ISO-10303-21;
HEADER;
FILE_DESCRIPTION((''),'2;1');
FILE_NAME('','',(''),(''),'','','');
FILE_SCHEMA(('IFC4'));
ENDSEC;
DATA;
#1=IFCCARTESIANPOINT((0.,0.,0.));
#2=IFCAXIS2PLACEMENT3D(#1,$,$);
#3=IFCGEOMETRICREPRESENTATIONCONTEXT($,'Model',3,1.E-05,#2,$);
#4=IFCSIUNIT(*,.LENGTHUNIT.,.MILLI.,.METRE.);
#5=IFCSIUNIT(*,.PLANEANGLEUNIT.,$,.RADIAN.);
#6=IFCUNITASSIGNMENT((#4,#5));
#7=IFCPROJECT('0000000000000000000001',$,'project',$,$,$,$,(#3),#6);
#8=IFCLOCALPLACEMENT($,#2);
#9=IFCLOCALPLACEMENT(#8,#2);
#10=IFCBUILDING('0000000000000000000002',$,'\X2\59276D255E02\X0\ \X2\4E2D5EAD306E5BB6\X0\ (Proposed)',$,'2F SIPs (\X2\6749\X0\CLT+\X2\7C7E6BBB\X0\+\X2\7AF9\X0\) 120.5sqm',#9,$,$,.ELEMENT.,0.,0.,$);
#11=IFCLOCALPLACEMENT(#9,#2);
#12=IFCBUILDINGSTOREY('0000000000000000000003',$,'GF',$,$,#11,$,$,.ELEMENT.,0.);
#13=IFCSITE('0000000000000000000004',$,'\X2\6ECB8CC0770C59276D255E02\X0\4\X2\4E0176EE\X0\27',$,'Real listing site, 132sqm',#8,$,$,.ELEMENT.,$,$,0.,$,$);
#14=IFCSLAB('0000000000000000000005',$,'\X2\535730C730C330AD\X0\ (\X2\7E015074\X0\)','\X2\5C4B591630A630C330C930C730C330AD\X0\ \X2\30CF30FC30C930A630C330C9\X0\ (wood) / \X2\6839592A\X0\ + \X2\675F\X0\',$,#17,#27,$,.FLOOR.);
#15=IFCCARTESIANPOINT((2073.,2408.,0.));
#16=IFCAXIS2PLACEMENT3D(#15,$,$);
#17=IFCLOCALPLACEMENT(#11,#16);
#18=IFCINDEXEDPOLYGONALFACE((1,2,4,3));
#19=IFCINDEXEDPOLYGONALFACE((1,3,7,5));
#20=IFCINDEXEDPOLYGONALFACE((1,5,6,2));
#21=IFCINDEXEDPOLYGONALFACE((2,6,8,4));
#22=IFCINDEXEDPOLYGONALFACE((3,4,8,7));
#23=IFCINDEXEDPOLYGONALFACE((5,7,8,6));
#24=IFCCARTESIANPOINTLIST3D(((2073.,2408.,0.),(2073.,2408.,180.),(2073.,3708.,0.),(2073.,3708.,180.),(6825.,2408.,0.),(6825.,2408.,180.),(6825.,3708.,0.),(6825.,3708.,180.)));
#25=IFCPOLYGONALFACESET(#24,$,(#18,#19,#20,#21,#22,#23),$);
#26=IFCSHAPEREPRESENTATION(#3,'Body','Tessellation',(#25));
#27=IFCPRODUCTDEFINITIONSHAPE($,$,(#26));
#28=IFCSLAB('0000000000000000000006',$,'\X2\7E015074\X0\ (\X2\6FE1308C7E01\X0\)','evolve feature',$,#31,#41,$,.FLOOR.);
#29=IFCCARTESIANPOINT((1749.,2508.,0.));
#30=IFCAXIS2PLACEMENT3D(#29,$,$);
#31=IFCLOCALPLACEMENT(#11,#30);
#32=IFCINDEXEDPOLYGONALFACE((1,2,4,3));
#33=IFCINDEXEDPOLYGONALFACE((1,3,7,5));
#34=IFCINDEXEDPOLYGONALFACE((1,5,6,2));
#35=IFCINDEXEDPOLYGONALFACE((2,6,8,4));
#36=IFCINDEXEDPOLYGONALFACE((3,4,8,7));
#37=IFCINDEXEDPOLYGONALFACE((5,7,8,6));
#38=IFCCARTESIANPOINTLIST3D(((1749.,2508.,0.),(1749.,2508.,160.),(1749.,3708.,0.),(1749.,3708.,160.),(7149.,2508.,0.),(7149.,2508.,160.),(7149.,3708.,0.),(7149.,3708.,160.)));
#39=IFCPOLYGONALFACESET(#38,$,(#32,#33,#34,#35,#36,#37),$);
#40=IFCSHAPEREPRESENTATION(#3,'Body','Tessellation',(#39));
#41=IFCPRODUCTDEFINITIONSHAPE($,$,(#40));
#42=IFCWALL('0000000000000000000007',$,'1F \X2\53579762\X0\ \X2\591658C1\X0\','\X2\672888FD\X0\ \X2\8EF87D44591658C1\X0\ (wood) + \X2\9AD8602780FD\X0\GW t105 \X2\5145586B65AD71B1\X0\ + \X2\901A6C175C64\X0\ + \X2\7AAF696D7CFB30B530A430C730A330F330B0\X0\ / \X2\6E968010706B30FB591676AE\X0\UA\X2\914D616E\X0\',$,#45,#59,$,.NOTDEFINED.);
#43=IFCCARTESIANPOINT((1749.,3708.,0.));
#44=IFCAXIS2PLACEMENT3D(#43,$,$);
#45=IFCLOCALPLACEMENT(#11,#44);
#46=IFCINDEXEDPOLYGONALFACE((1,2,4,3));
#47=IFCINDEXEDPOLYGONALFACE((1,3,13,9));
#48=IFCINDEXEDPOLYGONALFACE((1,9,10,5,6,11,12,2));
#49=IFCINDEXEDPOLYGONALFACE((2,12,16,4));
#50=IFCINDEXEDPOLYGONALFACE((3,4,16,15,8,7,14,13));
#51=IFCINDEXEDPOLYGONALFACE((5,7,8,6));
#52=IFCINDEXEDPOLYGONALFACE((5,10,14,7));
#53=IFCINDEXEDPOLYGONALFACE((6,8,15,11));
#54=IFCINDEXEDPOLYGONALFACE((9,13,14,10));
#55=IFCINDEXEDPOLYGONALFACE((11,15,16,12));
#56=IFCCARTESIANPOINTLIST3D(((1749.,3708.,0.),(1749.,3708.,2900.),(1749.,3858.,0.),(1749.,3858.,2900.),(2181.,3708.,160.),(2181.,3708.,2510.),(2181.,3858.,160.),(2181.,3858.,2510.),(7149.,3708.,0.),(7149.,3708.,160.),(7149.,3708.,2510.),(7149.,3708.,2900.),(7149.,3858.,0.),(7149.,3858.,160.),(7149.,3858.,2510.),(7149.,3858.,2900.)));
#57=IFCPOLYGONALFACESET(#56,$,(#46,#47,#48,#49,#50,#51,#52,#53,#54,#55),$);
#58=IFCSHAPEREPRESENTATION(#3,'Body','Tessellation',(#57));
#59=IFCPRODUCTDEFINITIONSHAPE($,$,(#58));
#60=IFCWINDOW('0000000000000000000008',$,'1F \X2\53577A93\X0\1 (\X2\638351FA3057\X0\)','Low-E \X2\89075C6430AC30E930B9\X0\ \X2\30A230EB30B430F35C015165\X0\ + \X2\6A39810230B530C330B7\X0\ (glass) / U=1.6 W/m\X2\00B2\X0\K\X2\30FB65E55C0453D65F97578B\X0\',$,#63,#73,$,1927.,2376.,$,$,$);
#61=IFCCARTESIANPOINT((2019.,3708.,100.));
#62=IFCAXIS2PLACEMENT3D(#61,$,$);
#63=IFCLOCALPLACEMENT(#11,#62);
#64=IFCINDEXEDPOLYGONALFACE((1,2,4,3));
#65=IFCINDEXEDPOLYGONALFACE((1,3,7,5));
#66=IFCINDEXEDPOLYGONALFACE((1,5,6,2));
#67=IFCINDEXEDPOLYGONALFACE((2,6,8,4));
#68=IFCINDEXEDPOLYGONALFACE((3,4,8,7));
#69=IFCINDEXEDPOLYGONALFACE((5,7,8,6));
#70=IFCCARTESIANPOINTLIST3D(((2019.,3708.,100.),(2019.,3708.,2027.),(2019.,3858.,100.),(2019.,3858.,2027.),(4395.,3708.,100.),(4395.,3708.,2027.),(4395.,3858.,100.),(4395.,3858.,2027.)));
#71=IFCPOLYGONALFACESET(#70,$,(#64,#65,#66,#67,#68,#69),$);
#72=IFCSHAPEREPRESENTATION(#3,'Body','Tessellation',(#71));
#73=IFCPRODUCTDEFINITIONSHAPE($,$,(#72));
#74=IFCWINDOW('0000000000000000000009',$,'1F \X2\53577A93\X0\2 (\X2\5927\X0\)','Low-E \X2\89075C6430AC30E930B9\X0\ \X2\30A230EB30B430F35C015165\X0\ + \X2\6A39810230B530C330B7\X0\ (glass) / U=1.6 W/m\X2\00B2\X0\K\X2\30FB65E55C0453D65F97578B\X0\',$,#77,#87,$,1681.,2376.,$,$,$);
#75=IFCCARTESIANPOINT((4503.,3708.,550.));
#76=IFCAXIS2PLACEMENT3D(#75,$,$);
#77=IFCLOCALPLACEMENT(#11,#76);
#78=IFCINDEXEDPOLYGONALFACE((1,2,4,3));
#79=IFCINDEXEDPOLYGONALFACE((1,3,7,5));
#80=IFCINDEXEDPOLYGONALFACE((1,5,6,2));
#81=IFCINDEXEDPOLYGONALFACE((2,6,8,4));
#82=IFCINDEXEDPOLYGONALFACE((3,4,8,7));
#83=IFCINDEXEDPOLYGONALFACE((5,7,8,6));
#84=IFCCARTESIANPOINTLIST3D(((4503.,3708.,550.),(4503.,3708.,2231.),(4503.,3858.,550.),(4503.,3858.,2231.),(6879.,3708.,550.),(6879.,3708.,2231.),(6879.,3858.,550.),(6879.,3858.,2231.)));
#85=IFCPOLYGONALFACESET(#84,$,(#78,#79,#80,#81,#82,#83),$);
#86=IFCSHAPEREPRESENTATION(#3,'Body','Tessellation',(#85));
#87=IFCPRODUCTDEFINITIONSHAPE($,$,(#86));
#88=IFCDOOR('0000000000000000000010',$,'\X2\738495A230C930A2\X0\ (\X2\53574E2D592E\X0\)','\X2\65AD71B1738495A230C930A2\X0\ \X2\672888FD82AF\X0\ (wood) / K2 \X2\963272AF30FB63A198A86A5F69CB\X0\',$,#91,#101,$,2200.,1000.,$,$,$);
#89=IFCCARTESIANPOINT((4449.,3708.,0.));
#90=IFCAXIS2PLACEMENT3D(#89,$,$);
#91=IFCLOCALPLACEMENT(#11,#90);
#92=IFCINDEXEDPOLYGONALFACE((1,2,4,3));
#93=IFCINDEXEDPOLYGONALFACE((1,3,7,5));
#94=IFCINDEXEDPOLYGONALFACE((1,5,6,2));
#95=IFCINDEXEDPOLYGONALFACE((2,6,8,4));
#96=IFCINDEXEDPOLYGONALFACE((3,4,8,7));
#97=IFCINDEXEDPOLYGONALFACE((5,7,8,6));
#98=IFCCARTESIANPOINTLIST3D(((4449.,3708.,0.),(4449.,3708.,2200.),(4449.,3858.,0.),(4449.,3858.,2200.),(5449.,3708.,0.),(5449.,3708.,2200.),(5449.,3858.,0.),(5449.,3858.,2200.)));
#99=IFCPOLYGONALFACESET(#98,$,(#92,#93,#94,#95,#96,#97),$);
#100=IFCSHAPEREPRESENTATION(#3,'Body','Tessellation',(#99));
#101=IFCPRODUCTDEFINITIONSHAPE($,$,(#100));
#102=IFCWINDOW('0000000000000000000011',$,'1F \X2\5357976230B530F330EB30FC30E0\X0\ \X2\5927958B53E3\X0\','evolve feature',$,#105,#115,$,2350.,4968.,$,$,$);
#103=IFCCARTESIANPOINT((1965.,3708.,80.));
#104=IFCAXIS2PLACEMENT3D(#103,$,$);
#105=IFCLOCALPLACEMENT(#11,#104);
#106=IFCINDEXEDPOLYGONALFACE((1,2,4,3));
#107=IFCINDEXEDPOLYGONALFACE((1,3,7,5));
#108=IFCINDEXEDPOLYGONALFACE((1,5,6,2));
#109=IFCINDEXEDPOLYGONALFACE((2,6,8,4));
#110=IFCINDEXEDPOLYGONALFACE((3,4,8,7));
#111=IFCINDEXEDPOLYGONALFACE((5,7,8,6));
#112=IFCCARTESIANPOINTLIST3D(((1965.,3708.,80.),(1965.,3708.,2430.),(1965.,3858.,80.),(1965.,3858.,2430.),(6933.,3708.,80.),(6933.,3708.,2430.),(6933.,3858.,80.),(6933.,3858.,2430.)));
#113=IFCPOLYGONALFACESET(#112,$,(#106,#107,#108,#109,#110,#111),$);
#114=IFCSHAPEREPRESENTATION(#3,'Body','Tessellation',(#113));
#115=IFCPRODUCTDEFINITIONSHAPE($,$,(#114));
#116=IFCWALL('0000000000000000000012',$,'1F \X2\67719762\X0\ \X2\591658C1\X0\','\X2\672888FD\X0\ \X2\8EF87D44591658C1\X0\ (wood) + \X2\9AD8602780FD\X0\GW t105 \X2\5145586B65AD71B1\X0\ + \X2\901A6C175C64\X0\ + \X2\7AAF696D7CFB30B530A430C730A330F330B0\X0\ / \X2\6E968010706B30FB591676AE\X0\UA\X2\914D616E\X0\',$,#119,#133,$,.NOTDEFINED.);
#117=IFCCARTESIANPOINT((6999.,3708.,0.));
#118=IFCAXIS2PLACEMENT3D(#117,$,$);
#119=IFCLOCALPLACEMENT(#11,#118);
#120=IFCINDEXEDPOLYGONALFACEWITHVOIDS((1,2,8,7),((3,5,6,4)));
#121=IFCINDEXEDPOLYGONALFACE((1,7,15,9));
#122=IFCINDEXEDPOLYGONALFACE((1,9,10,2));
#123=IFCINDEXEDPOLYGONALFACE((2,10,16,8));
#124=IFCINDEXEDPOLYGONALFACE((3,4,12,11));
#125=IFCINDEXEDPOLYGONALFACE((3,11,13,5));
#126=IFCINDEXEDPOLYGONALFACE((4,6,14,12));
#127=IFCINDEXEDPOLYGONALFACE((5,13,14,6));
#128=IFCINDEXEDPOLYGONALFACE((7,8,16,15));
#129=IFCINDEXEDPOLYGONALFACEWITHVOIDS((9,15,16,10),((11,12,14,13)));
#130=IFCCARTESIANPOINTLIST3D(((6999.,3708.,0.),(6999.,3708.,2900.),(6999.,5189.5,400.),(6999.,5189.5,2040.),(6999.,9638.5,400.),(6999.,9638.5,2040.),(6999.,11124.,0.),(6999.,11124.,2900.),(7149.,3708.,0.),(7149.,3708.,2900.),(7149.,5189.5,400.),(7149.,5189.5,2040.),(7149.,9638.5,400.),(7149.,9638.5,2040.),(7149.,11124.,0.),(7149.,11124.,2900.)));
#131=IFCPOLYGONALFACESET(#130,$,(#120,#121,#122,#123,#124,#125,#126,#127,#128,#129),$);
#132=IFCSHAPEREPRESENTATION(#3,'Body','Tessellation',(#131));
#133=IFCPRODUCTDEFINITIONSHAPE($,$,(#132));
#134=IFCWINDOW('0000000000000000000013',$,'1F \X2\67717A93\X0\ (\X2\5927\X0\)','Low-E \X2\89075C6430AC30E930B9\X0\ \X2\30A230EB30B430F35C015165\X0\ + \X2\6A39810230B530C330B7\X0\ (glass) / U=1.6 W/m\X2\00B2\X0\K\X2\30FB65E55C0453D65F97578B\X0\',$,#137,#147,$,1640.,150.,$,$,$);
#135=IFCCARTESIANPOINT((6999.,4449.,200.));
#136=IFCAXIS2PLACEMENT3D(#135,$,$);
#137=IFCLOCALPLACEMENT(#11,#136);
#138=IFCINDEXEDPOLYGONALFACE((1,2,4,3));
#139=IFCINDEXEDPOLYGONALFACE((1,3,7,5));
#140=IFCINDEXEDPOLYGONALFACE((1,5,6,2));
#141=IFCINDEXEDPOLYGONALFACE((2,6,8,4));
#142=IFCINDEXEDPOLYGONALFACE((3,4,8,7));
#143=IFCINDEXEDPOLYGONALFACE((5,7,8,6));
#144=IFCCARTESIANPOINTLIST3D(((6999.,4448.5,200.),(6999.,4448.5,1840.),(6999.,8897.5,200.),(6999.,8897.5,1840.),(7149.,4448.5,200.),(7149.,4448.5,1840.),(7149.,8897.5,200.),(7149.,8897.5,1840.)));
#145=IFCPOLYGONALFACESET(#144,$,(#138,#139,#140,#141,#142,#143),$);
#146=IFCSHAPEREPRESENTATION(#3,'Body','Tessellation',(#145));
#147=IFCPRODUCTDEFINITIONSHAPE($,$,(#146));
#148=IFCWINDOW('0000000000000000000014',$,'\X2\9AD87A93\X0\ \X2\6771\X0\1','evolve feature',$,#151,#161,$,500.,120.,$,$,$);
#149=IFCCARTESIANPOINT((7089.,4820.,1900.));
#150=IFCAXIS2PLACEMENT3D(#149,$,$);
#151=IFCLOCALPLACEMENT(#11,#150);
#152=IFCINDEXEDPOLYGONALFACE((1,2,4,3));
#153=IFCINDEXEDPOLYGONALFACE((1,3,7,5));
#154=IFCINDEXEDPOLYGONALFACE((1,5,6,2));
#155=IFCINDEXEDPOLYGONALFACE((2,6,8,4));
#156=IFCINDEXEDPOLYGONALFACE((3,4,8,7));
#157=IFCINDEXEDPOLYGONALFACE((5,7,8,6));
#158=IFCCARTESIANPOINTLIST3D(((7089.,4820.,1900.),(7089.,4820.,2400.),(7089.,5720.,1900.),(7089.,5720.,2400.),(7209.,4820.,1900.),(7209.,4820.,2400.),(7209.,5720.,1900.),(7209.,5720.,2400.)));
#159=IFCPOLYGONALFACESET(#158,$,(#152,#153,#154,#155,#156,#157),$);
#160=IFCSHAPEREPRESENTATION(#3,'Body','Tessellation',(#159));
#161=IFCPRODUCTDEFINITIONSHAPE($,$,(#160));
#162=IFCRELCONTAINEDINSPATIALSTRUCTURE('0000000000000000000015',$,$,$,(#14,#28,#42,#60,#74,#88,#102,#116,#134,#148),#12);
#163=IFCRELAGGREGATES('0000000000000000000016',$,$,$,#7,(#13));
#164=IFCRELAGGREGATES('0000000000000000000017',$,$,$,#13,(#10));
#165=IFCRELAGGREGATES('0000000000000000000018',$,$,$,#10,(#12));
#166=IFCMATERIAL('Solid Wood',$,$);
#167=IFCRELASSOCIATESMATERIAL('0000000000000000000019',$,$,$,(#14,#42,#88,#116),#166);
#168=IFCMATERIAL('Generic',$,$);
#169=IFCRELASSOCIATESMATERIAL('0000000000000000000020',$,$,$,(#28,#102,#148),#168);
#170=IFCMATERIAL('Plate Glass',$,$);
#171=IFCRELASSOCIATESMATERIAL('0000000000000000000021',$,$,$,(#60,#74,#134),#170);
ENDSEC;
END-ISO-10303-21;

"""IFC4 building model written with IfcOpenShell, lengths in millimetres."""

from ifc_helpers import new_model, si_unit, frame, frame_2d, origin, place, context, project, spatial, rectangle, extrude, material, element, fill, save


model = new_model("IFC4")

# Units and contexts
model_context = context("Model", 3, precision=1e-05, world=origin())
ifc_project = project(units=[si_unit("LENGTHUNIT", "METRE", prefix="MILLI"), si_unit("PLANEANGLEUNIT", "RADIAN")], contexts=[model_context])

# Site, building, storey
site_placement = place(None, origin())
site = spatial("IfcSite", under=ifc_project, at=site_placement, Name="滋賀県大津市4丁目27", ObjectType="Real listing site, 132sqm", CompositionType="ELEMENT", RefElevation=0.0)
building_placement = place(site_placement, origin())
building = spatial("IfcBuilding", under=site, at=building_placement, Name="大津市 中庭の家 (Proposed)", ObjectType="2F SIPs (杉CLT+籾殻+竹) 120.5sqm", CompositionType="ELEMENT", ElevationOfRefHeight=0.0, ElevationOfTerrain=0.0)
storey_placement = place(building_placement, origin())
storey = spatial("IfcBuildingStorey", under=building, at=storey_placement, Name="GF", CompositionType="ELEMENT", Elevation=0.0)

# Slabs
ifc_material_1 = material(Name="Solid Wood")
slab_1_placement = place(storey_placement, frame((2073.0, 2408.0, 0.0)))
element("IfcSlab", 1, at=slab_1_placement, inside=storey, material=ifc_material_1, Name="南デッキ (縁側)", Description="屋外ウッドデッキ ハードウッド (wood) / 根太 + 束", PredefinedType="FLOOR", context=model_context, shape_type="SweptSolid", body=[
    extrude(rectangle(XDim=4752.0, YDim=1300.0, at=frame_2d((2376.0, 650.0))), frame((2073.0, 2408.0, 0.0)), (0.0, 0.0, 1.0), 180.0),
])
ifc_material_2 = material(Name="Generic")
slab_2_placement = place(storey_placement, frame((1749.0, 2508.0, 0.0)))
element("IfcSlab", 2, at=slab_2_placement, inside=storey, material=ifc_material_2, Name="縁側 (濡れ縁)", Description="evolve feature", PredefinedType="FLOOR", context=model_context, shape_type="SweptSolid", body=[
    extrude(rectangle(XDim=5400.0, YDim=1200.0, at=frame_2d((2700.0, 600.0))), frame((1749.0, 2508.0, 0.0)), (0.0, 0.0, 1.0), 160.0),
])

# Wall, openings, windows, door
wall_1_placement = place(storey_placement, frame((1749.0, 3708.0, 0.0)))
wall_1 = element("IfcWall", 3, at=wall_1_placement, inside=storey, material=ifc_material_1, Name="1F 南面 外壁", Description="木製 軸組外壁 (wood) + 高性能GW t105 充填断熱 + 通気層 + 窯業系サイディング / 準耐火・外皮UA配慮", PredefinedType="NOTDEFINED", context=model_context, shape_type="SweptSolid", body=[
    extrude(rectangle(XDim=5400.0, YDim=150.0, at=frame_2d((2700.0, 75.0))), frame((1749.0, 3708.0, 0.0)), (0.0, 0.0, 1.0), 2900.0),
])
opening_1_placement = place(storey_placement, frame((2019.0, 3708.0, 100.0)))
opening_1 = element("IfcOpeningElement", 4, at=opening_1_placement, cuts=wall_1, PredefinedType="NOTDEFINED", context=model_context, shape_type="SweptSolid", body=[
    extrude(rectangle(XDim=2376.0, YDim=150.0, at=frame_2d((1188.0, 75.0))), frame((2019.0, 3708.0, 100.0)), (0.0, 0.0, 1.0), 1927.0),
])
opening_2_placement = place(storey_placement, frame((4503.0, 3708.0, 550.0)))
opening_2 = element("IfcOpeningElement", 5, at=opening_2_placement, cuts=wall_1, PredefinedType="NOTDEFINED", context=model_context, shape_type="SweptSolid", body=[
    extrude(rectangle(XDim=2376.0, YDim=150.0, at=frame_2d((1188.0, 75.0))), frame((4503.0, 3708.0, 550.0)), (0.0, 0.0, 1.0), 1681.0),
])
opening_3_placement = place(storey_placement, frame((4449.0, 3708.0, 0.0)))
opening_3 = element("IfcOpeningElement", 6, at=opening_3_placement, cuts=wall_1, PredefinedType="NOTDEFINED", context=model_context, shape_type="SweptSolid", body=[
    extrude(rectangle(XDim=1000.0, YDim=150.0, at=frame_2d((500.0, 75.0))), frame((4449.0, 3708.0, 0.0)), (0.0, 0.0, 1.0), 2200.0),
])
opening_4_placement = place(storey_placement, frame((1965.0, 3708.0, 80.0)))
opening_4 = element("IfcOpeningElement", 7, at=opening_4_placement, cuts=wall_1, PredefinedType="NOTDEFINED", context=model_context, shape_type="SweptSolid", body=[
    extrude(rectangle(XDim=4968.0, YDim=150.0, at=frame_2d((2484.0, 75.0))), frame((1965.0, 3708.0, 80.0)), (0.0, 0.0, 1.0), 2350.0),
])
ifc_material_3 = material(Name="Plate Glass")
window_1_placement = place(storey_placement, frame((2019.0, 3708.0, 100.0)))
window_1 = element("IfcWindow", 8, at=window_1_placement, inside=storey, material=ifc_material_3, Name="1F 南窓1 (掃出し)", Description="Low-E 複層ガラス アルゴン封入 + 樹脂サッシ (glass) / U=1.6 W/m²K・日射取得型", OverallHeight=1927.0, OverallWidth=2376.0, context=model_context, shape_type="SweptSolid", body=[
    extrude(rectangle(XDim=2376.0, YDim=150.0, at=frame_2d((1188.0, 75.0))), frame((2019.0, 3708.0, 100.0)), (0.0, 0.0, 1.0), 1927.0),
])
fill(opening_1, window_1)
window_2_placement = place(storey_placement, frame((4503.0, 3708.0, 550.0)))
window_2 = element("IfcWindow", 9, at=window_2_placement, inside=storey, material=ifc_material_3, Name="1F 南窓2 (大)", Description="Low-E 複層ガラス アルゴン封入 + 樹脂サッシ (glass) / U=1.6 W/m²K・日射取得型", OverallHeight=1681.0, OverallWidth=2376.0, context=model_context, shape_type="SweptSolid", body=[
    extrude(rectangle(XDim=2376.0, YDim=150.0, at=frame_2d((1188.0, 75.0))), frame((4503.0, 3708.0, 550.0)), (0.0, 0.0, 1.0), 1681.0),
])
fill(opening_2, window_2)
door_placement = place(storey_placement, frame((4449.0, 3708.0, 0.0)))
door = element("IfcDoor", 10, at=door_placement, inside=storey, material=ifc_material_1, Name="玄関ドア (南中央)", Description="断熱玄関ドア 木製芯 (wood) / K2 防犯・採風機構", OverallHeight=2200.0, OverallWidth=1000.0, context=model_context, shape_type="SweptSolid", body=[
    extrude(rectangle(XDim=1000.0, YDim=150.0, at=frame_2d((500.0, 75.0))), frame((4449.0, 3708.0, 0.0)), (0.0, 0.0, 1.0), 2200.0),
])
fill(opening_3, door)
window_3_placement = place(storey_placement, frame((1965.0, 3708.0, 80.0)))
window_3 = element("IfcWindow", 11, at=window_3_placement, inside=storey, material=ifc_material_2, Name="1F 南面サンルーム 大開口", Description="evolve feature", OverallHeight=2350.0, OverallWidth=4968.0, context=model_context, shape_type="SweptSolid", body=[
    extrude(rectangle(XDim=4968.0, YDim=150.0, at=frame_2d((2484.0, 75.0))), frame((1965.0, 3708.0, 80.0)), (0.0, 0.0, 1.0), 2350.0),
])
fill(opening_4, window_3)

# Wall, openings, windows
wall_2_placement = place(storey_placement, frame((6999.0, 3708.0, 0.0)))
wall_2 = element("IfcWall", 12, at=wall_2_placement, inside=storey, material=ifc_material_1, Name="1F 東面 外壁", Description="木製 軸組外壁 (wood) + 高性能GW t105 充填断熱 + 通気層 + 窯業系サイディング / 準耐火・外皮UA配慮", PredefinedType="NOTDEFINED", context=model_context, shape_type="SweptSolid", body=[
    extrude(rectangle(XDim=150.0, YDim=7416.0, at=frame_2d((75.0, 3708.0))), frame((6999.0, 3708.0, 0.0)), (0.0, 0.0, 1.0), 2900.0),
])
opening_5_placement = place(storey_placement, frame((6999.0, 4449.0, 200.0)))
opening_5 = element("IfcOpeningElement", 13, at=opening_5_placement, cuts=wall_2, PredefinedType="NOTDEFINED", context=model_context, shape_type="SweptSolid", body=[
    extrude(rectangle(XDim=150.0, YDim=4449.0, at=frame_2d((75.0, 2224.0))), frame((6999.0, 4449.0, 200.0)), (0.0, 0.0, 1.0), 1640.0),
])
opening_6_placement = place(storey_placement, frame((7089.0, 4820.0, 1900.0)))
opening_6 = element("IfcOpeningElement", 14, at=opening_6_placement, cuts=wall_2, PredefinedType="NOTDEFINED", context=model_context, shape_type="SweptSolid", body=[
    extrude(rectangle(XDim=120.0, YDim=900.0, at=frame_2d((60.0, 450.0))), frame((7089.0, 4820.0, 1900.0)), (0.0, 0.0, 1.0), 500.0),
])
window_4_placement = place(storey_placement, frame((6999.0, 4449.0, 200.0)))
window_4 = element("IfcWindow", 15, at=window_4_placement, inside=storey, material=ifc_material_3, Name="1F 東窓 (大)", Description="Low-E 複層ガラス アルゴン封入 + 樹脂サッシ (glass) / U=1.6 W/m²K・日射取得型", OverallHeight=1640.0, OverallWidth=150.0, context=model_context, shape_type="SweptSolid", body=[
    extrude(rectangle(XDim=150.0, YDim=4449.0, at=frame_2d((75.0, 2224.0))), frame((6999.0, 4449.0, 200.0)), (0.0, 0.0, 1.0), 1640.0),
])
fill(opening_5, window_4)
window_5_placement = place(storey_placement, frame((7089.0, 4820.0, 1900.0)))
window_5 = element("IfcWindow", 16, at=window_5_placement, inside=storey, material=ifc_material_2, Name="高窓 東1", Description="evolve feature", OverallHeight=500.0, OverallWidth=120.0, context=model_context, shape_type="SweptSolid", body=[
    extrude(rectangle(XDim=120.0, YDim=900.0, at=frame_2d((60.0, 450.0))), frame((7089.0, 4820.0, 1900.0)), (0.0, 0.0, 1.0), 500.0),
])
fill(opening_6, window_5)

save(model, "model.ifc")
